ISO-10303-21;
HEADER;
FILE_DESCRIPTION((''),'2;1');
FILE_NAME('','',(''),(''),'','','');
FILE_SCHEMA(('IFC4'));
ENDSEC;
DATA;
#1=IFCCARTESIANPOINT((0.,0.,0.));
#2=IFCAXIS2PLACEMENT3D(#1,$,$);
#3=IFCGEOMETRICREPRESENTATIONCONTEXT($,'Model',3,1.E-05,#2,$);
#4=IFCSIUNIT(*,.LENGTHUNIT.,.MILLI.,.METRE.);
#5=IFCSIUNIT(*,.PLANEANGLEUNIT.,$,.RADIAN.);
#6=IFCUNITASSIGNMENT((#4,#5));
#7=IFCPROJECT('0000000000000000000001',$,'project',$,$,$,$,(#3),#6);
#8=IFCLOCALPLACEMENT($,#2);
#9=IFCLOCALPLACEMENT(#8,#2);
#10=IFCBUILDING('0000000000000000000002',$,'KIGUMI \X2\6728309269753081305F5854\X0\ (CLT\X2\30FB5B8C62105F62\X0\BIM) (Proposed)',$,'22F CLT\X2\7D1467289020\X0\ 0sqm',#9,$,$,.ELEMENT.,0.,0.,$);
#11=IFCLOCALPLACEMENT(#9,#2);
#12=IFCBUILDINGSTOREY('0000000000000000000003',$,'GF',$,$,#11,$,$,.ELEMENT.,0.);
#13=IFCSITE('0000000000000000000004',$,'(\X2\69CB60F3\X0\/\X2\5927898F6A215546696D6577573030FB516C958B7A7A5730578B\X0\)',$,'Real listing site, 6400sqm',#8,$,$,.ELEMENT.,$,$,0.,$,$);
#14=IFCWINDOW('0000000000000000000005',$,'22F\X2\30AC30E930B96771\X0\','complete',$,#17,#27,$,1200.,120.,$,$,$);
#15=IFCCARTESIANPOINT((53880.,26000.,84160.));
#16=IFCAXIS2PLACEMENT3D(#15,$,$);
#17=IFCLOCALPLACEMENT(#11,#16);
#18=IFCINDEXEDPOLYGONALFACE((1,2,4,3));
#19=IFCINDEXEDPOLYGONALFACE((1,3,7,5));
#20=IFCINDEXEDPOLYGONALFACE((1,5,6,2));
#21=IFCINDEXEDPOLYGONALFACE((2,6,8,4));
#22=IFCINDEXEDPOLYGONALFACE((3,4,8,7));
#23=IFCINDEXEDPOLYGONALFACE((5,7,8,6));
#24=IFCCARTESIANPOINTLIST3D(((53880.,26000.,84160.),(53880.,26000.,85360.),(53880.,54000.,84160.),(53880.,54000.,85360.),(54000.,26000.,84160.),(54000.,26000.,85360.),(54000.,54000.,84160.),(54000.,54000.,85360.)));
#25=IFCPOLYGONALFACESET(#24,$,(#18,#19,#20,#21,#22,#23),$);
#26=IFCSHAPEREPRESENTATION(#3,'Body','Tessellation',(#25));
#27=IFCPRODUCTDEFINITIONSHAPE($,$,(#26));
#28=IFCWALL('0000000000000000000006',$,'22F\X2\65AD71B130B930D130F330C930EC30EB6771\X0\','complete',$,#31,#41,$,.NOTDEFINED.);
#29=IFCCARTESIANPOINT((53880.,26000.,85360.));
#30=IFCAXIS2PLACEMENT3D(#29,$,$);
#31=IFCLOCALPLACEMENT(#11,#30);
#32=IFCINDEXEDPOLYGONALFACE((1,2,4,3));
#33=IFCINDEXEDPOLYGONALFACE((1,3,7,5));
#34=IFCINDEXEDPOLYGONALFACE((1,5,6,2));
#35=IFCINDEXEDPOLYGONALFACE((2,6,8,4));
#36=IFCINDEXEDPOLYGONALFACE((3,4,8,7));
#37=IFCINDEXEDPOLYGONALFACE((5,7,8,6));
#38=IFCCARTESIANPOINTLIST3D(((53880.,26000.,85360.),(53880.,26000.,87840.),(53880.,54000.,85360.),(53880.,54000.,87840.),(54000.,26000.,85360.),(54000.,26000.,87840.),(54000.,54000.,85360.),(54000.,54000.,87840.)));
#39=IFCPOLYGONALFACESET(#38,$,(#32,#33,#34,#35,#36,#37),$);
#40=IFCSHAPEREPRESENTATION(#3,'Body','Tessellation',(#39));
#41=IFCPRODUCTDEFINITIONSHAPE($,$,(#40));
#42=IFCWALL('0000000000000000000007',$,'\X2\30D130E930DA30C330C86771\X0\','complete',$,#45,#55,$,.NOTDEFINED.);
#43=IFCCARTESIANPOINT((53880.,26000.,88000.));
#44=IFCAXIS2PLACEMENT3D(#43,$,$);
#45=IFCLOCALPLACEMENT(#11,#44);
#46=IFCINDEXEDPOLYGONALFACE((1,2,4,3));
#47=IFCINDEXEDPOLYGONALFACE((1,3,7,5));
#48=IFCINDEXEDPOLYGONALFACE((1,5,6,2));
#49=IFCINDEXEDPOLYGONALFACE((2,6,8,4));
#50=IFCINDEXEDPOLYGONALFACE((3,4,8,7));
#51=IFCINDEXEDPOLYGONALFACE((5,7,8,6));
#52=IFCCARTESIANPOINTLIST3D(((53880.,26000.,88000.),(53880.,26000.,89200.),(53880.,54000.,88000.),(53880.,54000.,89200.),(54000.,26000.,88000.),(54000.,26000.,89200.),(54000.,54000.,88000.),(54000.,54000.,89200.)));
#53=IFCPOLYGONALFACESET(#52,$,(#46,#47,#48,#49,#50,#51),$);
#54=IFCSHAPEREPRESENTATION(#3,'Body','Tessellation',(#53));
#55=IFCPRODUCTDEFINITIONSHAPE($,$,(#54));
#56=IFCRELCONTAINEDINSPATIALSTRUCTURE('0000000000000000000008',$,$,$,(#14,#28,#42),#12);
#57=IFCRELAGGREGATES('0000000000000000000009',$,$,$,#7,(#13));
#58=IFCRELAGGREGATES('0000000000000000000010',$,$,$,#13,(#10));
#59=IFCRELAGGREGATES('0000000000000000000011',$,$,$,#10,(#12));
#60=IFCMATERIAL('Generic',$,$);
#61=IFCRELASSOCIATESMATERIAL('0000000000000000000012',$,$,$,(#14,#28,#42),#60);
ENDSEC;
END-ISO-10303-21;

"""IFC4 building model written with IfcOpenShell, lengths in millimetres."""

from ifc_helpers import new_model, si_unit, frame, frame_2d, origin, place, context, project, spatial, rectangle, extrude, material, element, save


model = new_model("IFC4")

# Units and contexts
model_context = context("Model", 3, precision=1e-05, world=origin())
ifc_project = project(units=[si_unit("LENGTHUNIT", "METRE", prefix="MILLI"), si_unit("PLANEANGLEUNIT", "RADIAN")], contexts=[model_context])

# Site, building, storey
site_placement = place(None, origin())
site = spatial("IfcSite", under=ifc_project, at=site_placement, Name="(構想/大規模商業敷地・公開空地型)", ObjectType="Real listing site, 6400sqm", CompositionType="ELEMENT", RefElevation=0.0)
building_placement = place(site_placement, origin())
building = spatial("IfcBuilding", under=site, at=building_placement, Name="KIGUMI 木を極めた塔 (CLT・完成形BIM) (Proposed)", ObjectType="22F CLT純木造 0sqm", CompositionType="ELEMENT", ElevationOfRefHeight=0.0, ElevationOfTerrain=0.0)
storey_placement = place(building_placement, origin())
storey = spatial("IfcBuildingStorey", under=building, at=storey_placement, Name="GF", CompositionType="ELEMENT", Elevation=0.0)

# Shared definitions
ifc_material = material(Name="Generic")

# Window
window_1_placement = place(storey_placement, frame((53880.0, 26000.0, 84160.0)))
element("IfcWindow", 1, at=window_1_placement, inside=storey, material=ifc_material, Name="22Fガラス東", Description="complete", OverallHeight=1200.0, OverallWidth=120.0, context=model_context, shape_type="SweptSolid", body=[
    extrude(rectangle(XDim=120.0, YDim=28000.0, at=frame_2d((60.0, 14000.0))), frame((53880.0, 26000.0, 84160.0)), (0.0, 0.0, 1.0), 1200.0),
])

# Walls
wall_1_placement = place(storey_placement, frame((53880.0, 26000.0, 85360.0)))
element("IfcWall", 2, at=wall_1_placement, inside=storey, material=ifc_material, Name="22F断熱スパンドレル東", Description="complete", PredefinedType="NOTDEFINED", context=model_context, shape_type="SweptSolid", body=[
    extrude(rectangle(XDim=120.0, YDim=28000.0, at=frame_2d((60.0, 14000.0))), frame((53880.0, 26000.0, 85360.0)), (0.0, 0.0, 1.0), 2480.0),
])
wall_2_placement = place(storey_placement, frame((53880.0, 26000.0, 88000.0)))
element("IfcWall", 3, at=wall_2_placement, inside=storey, material=ifc_material, Name="パラペット東", Description="complete", PredefinedType="NOTDEFINED", context=model_context, shape_type="SweptSolid", body=[
    extrude(rectangle(XDim=120.0, YDim=28000.0, at=frame_2d((60.0, 14000.0))), frame((53880.0, 26000.0, 88000.0)), (0.0, 0.0, 1.0), 1200.0),
])

save(model, "model.ifc")
